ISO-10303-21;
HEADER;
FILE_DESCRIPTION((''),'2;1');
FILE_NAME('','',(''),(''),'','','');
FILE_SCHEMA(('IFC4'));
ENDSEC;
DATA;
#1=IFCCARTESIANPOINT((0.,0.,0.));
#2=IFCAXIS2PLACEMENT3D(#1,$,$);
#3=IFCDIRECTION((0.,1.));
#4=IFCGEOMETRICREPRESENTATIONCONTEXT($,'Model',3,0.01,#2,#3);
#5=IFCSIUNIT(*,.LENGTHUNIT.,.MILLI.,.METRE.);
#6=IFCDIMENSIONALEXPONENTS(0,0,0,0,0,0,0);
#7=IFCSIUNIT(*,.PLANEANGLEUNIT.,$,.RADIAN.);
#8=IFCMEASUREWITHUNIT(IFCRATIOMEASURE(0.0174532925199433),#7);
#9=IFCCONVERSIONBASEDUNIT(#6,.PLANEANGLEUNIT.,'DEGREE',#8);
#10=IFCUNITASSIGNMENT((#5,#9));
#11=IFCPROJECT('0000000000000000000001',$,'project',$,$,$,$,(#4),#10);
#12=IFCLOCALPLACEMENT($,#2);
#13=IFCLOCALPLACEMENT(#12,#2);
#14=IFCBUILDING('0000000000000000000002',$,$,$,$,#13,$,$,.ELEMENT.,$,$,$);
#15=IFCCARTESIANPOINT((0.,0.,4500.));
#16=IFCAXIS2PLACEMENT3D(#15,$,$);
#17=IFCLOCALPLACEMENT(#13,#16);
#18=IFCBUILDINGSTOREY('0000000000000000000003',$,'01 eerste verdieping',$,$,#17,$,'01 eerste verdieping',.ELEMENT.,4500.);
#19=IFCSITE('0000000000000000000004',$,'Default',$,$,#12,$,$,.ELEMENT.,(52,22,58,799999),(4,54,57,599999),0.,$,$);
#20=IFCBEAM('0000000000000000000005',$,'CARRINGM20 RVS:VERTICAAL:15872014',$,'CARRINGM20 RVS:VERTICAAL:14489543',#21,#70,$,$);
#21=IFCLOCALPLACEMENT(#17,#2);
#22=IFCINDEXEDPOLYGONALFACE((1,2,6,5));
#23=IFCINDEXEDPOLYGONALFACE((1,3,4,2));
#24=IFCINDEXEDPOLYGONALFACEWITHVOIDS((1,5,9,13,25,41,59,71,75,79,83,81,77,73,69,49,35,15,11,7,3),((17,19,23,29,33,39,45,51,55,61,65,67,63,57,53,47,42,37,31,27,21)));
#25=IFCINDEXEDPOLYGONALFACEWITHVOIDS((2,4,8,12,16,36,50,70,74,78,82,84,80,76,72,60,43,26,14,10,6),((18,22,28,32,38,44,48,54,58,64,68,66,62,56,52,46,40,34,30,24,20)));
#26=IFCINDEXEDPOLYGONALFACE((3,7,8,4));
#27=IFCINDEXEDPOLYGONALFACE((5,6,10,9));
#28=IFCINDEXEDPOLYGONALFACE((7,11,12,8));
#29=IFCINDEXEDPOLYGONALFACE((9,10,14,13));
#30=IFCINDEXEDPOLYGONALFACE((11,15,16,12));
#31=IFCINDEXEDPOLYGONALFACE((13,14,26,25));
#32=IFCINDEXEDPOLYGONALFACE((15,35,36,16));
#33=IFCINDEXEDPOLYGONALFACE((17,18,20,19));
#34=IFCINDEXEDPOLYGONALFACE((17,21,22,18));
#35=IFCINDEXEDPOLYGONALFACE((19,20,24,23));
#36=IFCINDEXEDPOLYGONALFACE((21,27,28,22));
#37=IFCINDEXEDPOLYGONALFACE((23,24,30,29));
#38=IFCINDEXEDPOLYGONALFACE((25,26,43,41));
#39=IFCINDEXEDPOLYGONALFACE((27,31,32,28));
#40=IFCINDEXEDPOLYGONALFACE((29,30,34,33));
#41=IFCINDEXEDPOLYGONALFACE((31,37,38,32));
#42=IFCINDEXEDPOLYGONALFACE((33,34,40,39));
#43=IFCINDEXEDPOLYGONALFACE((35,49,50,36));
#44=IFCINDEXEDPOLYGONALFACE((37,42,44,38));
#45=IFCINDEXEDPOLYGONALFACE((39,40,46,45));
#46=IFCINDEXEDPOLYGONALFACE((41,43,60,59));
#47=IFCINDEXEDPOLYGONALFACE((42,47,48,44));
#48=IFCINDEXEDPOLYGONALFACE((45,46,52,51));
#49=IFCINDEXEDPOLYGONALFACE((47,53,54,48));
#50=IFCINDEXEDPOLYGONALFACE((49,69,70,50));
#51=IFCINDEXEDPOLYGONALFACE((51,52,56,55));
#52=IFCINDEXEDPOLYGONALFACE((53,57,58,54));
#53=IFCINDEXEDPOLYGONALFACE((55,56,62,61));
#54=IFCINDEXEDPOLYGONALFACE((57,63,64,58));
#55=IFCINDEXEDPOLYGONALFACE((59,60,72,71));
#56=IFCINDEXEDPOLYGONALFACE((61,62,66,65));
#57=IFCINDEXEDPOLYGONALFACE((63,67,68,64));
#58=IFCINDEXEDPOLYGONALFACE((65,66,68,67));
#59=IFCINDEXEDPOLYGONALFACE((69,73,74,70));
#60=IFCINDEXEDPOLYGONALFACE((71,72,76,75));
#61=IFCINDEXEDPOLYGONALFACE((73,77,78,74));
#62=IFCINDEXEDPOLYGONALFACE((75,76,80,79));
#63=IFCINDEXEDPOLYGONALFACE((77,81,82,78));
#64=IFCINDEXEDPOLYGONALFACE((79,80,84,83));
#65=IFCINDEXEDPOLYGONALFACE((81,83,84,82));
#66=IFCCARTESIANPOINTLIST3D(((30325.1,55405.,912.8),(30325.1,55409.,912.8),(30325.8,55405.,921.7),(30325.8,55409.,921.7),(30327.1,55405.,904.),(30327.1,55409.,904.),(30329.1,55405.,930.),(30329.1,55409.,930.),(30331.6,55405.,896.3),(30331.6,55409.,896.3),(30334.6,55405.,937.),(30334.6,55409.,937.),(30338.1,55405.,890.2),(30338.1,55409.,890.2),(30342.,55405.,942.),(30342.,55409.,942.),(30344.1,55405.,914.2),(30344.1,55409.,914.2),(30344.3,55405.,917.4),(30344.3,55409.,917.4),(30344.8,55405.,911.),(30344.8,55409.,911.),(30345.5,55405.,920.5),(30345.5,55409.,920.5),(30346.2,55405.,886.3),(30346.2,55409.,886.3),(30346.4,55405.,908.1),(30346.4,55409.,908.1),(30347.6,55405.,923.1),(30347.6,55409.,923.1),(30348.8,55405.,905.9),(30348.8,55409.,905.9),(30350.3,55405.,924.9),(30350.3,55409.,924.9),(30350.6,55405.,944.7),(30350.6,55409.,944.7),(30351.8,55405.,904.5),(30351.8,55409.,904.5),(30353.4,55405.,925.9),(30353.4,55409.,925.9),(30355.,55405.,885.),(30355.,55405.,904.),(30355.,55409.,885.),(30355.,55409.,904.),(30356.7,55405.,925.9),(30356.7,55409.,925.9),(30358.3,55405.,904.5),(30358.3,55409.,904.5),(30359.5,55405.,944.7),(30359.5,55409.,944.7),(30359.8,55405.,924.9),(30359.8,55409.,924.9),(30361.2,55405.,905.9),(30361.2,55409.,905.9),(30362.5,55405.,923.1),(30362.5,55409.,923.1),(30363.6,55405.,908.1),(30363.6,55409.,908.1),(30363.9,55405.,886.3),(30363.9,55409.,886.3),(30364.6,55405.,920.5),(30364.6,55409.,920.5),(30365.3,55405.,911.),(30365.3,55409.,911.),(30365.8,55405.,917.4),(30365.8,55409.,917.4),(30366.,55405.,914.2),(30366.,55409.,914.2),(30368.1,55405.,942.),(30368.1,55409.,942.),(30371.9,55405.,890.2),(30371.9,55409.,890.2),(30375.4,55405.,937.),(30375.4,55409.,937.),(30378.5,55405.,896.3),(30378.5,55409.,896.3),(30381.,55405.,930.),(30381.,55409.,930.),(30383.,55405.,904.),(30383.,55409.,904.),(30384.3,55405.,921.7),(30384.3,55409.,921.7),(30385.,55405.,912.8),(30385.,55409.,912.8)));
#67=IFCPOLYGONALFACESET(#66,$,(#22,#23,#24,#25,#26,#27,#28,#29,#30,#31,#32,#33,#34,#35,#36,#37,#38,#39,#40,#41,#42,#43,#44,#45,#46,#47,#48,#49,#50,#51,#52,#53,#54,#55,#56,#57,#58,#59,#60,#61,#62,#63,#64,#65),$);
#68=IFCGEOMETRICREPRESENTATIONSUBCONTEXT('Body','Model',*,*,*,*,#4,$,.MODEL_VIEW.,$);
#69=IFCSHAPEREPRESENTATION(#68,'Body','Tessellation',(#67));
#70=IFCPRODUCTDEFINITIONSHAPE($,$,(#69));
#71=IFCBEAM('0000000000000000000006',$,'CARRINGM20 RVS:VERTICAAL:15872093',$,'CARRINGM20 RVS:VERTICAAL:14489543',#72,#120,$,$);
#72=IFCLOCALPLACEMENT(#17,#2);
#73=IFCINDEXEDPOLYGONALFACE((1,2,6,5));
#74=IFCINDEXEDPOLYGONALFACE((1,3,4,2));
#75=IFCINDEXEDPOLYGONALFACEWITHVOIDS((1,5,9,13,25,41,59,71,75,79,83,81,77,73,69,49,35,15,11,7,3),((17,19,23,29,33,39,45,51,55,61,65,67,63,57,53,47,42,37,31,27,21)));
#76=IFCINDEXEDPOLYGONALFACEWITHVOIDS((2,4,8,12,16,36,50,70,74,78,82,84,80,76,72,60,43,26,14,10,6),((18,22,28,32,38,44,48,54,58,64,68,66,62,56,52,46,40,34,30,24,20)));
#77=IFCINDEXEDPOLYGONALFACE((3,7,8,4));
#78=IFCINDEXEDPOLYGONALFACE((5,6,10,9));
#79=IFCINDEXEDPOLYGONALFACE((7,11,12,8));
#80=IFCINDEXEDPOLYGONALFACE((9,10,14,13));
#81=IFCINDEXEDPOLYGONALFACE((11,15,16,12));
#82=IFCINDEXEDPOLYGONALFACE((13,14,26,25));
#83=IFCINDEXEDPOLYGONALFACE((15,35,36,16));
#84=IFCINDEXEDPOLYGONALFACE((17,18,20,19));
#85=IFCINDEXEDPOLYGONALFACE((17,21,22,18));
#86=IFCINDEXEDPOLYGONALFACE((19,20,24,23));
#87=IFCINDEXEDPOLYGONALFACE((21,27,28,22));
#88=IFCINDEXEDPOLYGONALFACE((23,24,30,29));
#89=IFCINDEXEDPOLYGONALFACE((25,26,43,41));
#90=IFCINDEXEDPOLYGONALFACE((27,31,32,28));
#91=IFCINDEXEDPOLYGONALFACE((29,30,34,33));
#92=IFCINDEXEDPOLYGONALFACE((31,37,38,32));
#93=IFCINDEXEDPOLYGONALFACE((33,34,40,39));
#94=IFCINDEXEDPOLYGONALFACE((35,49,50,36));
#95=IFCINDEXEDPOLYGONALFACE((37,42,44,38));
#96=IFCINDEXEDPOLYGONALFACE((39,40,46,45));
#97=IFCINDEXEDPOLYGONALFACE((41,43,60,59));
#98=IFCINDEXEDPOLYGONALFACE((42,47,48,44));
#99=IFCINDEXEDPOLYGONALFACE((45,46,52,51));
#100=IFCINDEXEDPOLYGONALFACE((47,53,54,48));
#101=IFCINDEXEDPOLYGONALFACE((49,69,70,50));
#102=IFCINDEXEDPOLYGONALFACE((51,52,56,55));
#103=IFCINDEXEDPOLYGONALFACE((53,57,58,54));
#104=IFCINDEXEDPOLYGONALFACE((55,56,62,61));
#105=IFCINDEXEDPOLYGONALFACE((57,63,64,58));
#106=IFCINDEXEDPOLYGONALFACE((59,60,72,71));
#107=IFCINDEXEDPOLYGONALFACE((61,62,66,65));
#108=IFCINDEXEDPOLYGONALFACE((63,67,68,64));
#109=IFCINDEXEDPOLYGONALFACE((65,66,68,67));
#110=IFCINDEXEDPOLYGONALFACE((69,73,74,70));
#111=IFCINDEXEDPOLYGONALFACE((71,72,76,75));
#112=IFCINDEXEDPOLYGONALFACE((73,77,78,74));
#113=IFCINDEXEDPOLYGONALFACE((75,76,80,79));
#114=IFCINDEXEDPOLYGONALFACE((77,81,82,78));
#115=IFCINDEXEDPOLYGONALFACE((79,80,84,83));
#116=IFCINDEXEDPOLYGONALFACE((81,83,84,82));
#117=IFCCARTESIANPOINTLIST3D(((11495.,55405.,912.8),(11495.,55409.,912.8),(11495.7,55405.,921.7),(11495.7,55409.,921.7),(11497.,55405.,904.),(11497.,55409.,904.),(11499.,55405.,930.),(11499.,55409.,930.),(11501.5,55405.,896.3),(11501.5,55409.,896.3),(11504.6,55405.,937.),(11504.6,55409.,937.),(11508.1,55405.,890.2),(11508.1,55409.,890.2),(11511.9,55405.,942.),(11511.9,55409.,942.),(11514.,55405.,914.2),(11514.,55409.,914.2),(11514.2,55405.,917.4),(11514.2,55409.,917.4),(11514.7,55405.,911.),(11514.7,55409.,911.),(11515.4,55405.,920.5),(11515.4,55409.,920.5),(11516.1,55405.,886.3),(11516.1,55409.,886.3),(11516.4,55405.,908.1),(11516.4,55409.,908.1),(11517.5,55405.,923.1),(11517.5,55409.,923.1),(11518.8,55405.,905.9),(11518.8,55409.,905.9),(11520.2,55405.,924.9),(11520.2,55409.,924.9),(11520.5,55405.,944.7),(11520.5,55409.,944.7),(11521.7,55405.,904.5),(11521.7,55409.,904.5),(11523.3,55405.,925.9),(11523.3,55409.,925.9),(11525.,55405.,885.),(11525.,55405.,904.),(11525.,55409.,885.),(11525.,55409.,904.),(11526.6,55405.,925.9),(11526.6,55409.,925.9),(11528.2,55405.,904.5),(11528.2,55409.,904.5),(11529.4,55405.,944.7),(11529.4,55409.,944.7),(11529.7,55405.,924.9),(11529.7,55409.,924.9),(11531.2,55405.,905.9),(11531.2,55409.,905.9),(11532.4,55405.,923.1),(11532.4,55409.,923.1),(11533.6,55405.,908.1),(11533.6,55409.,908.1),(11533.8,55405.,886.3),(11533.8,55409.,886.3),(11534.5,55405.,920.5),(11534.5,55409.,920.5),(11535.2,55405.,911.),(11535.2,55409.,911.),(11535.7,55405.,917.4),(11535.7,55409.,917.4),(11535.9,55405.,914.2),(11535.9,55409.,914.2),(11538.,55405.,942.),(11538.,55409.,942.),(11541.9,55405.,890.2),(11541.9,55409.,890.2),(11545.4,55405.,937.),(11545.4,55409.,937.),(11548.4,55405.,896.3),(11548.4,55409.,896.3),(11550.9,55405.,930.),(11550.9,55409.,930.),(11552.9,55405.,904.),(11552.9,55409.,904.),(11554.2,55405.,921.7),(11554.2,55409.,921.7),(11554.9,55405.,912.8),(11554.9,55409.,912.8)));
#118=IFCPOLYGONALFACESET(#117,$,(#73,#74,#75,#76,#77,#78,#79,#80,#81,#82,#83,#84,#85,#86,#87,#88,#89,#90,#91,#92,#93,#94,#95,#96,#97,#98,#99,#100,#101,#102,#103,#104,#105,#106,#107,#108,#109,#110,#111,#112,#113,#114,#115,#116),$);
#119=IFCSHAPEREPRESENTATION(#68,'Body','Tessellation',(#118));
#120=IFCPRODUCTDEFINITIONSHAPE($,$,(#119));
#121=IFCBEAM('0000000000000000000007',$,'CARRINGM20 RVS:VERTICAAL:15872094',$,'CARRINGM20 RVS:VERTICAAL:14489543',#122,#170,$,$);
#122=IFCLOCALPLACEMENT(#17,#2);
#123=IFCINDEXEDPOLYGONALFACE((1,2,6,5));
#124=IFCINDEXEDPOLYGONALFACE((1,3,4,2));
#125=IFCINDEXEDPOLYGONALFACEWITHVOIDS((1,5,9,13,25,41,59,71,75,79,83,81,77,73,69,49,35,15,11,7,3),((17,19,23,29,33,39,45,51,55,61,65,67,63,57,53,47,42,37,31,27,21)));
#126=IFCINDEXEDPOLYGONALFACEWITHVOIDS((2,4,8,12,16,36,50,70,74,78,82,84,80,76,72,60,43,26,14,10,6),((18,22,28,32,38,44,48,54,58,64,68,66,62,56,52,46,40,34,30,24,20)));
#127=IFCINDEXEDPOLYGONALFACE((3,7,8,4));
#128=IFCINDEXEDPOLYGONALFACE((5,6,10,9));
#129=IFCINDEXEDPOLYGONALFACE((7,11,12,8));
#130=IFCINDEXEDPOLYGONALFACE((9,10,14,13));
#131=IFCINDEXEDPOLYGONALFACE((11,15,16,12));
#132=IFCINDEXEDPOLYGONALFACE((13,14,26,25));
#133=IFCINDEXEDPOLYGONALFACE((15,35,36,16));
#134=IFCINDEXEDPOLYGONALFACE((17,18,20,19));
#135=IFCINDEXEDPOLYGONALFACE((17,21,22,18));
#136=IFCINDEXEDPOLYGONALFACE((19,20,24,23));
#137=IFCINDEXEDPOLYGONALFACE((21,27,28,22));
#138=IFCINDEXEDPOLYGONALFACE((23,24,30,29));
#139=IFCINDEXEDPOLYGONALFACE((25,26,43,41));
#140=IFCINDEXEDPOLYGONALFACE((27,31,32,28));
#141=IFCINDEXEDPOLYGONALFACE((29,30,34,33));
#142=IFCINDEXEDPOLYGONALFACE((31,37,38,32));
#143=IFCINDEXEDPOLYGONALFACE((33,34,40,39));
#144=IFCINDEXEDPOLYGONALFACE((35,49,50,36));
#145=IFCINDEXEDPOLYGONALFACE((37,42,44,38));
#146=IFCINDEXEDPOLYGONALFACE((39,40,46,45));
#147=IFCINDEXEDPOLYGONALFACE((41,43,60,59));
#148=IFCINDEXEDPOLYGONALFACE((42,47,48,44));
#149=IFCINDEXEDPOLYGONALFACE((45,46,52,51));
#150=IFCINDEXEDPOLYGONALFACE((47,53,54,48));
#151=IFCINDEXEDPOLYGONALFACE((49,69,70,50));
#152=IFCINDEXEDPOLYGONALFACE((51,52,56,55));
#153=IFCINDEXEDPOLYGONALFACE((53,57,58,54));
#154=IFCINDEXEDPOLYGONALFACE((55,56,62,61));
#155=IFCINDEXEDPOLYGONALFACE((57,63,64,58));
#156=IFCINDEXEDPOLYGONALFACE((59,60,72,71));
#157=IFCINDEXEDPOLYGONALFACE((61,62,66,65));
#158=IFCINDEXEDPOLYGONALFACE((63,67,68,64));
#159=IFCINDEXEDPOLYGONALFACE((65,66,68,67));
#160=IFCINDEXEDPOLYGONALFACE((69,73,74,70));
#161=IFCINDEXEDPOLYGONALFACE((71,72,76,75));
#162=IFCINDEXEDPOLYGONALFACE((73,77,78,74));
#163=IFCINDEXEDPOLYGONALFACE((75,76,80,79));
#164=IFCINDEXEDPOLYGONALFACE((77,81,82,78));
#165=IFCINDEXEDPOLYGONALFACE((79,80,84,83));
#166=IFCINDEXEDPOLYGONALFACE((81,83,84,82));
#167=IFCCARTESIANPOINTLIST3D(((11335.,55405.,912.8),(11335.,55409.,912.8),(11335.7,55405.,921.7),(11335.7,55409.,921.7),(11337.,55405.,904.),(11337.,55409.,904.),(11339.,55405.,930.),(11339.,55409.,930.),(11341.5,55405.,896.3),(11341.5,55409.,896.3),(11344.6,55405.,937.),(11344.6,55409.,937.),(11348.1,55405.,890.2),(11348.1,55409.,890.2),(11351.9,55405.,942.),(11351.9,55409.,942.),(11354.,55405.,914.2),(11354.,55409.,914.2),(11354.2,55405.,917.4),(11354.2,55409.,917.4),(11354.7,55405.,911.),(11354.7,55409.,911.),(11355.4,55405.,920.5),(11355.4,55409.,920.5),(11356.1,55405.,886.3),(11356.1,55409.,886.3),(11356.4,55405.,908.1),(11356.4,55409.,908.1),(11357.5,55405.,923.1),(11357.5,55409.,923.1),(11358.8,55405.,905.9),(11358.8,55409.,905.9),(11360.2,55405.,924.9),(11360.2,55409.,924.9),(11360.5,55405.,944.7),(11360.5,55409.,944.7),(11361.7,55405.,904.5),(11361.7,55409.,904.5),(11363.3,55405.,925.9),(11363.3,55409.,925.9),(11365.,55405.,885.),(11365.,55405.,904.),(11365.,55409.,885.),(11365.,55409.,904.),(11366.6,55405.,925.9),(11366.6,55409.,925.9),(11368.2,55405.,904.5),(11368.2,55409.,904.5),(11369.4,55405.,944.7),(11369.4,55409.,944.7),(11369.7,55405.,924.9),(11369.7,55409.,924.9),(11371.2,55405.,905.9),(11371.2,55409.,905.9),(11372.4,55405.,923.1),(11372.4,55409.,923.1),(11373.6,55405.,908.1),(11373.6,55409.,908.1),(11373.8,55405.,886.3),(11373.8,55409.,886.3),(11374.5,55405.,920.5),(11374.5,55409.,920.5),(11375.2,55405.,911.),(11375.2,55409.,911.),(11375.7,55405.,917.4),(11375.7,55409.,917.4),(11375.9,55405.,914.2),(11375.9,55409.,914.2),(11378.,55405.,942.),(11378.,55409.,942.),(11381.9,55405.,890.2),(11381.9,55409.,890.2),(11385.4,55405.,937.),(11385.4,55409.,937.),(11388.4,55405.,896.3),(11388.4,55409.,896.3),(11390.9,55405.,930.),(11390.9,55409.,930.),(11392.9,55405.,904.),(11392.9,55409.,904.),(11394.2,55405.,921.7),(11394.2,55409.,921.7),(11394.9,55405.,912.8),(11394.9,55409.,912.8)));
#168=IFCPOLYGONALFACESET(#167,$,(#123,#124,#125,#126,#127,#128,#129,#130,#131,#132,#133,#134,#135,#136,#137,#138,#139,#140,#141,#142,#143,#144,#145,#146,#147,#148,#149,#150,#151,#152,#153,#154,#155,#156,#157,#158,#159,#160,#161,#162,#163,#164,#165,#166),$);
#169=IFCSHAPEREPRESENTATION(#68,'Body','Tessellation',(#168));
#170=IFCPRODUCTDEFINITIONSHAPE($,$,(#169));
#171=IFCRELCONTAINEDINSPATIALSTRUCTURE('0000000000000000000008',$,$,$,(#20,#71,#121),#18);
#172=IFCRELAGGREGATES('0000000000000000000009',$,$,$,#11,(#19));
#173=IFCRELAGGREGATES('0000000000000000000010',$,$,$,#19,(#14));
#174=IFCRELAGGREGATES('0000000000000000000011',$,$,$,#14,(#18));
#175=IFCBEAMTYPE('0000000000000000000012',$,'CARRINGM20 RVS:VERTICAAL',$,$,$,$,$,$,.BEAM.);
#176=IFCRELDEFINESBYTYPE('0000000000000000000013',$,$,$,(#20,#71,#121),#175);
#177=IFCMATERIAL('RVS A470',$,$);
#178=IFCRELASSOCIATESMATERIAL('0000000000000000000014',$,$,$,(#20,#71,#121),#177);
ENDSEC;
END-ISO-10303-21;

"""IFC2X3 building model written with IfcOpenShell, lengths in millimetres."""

from ifc_helpers import new_model, entity, si_unit, converted_unit, direction, frame, origin, origin_2d_with_axis, place, context, subcontext, project, spatial, hollow_circle, extrude, material, type_object, element, save


model = new_model("IFC2X3")

# Units and contexts
model_context = context("Model", 3, precision=0.01, world=origin(), true_north=direction((0.0, 1.0)))
body_context = subcontext(model_context, "Body", "Model", "MODEL_VIEW")
ifc_project = project(units=[si_unit("LENGTHUNIT", "METRE", prefix="MILLI"), converted_unit("PLANEANGLEUNIT", "DEGREE", entity("IfcRatioMeasure", 0.0174532925199433), si_unit("PLANEANGLEUNIT", "RADIAN"), dimensions=[0, 0, 0, 0, 0, 0, 0])], contexts=[model_context])

# Site, building, storey
site_placement = place(None, origin())
site = spatial("IfcSite", under=ifc_project, at=site_placement, Name="Default", CompositionType="ELEMENT", RefLatitude=(52, 22, 58, 799999), RefLongitude=(4, 54, 57, 599999), RefElevation=0.0)
building_placement = place(site_placement, origin())
building = spatial("IfcBuilding", under=site, at=building_placement, CompositionType="ELEMENT")
storey_placement = place(building_placement, frame((0.0, 0.0, 4500.0)))
storey = spatial("IfcBuildingStorey", under=building, at=storey_placement, Name="01 eerste verdieping", LongName="01 eerste verdieping", CompositionType="ELEMENT", Elevation=4500.0)

# Beams
ifc_material_1 = material(Name="RVS A470")
beam_type_1 = type_object("IfcBeamType", Name="CARRINGM20 RVS:VERTICAAL", PredefinedType="BEAM")
beam_1_placement = place(storey_placement, origin())
element("IfcBeam", 1, at=beam_1_placement, inside=storey, type_object=beam_type_1, material=ifc_material_1, Name="CARRINGM20 RVS:VERTICAAL:15872014", ObjectType="CARRINGM20 RVS:VERTICAAL:14489543", context=body_context, shape_type="SweptSolid", body=[
    extrude(hollow_circle(Radius=30.0, WallThickness=19.0, at=origin_2d_with_axis()), frame((30355.0, 55405.0, 915.0), z_axis=(0.0, 1.0, 0.0), x_axis=(0.0, 0.0, -1.0)), (0.0, 0.0, 1.0), 4.0),
])
beam_2_placement = place(storey_placement, origin())
element("IfcBeam", 2, at=beam_2_placement, inside=storey, type_object=beam_type_1, material=ifc_material_1, Name="CARRINGM20 RVS:VERTICAAL:15872093", ObjectType="CARRINGM20 RVS:VERTICAAL:14489543", context=body_context, shape_type="SweptSolid", body=[
    extrude(hollow_circle(Radius=30.0, WallThickness=19.0, at=origin_2d_with_axis()), frame((11525.0, 55405.0, 915.0), z_axis=(0.0, 1.0, 0.0), x_axis=(0.0, 0.0, -1.0)), (0.0, 0.0, 1.0), 4.0),
])
beam_3_placement = place(storey_placement, origin())
element("IfcBeam", 3, at=beam_3_placement, inside=storey, type_object=beam_type_1, material=ifc_material_1, Name="CARRINGM20 RVS:VERTICAAL:15872094", ObjectType="CARRINGM20 RVS:VERTICAAL:14489543", context=body_context, shape_type="SweptSolid", body=[
    extrude(hollow_circle(Radius=30.0, WallThickness=19.0, at=origin_2d_with_axis()), frame((11365.0, 55405.0, 915.0), z_axis=(0.0, 1.0, 0.0), x_axis=(0.0, 0.0, -1.0)), (0.0, 0.0, 1.0), 4.0),
])

save(model, "model.ifc")
